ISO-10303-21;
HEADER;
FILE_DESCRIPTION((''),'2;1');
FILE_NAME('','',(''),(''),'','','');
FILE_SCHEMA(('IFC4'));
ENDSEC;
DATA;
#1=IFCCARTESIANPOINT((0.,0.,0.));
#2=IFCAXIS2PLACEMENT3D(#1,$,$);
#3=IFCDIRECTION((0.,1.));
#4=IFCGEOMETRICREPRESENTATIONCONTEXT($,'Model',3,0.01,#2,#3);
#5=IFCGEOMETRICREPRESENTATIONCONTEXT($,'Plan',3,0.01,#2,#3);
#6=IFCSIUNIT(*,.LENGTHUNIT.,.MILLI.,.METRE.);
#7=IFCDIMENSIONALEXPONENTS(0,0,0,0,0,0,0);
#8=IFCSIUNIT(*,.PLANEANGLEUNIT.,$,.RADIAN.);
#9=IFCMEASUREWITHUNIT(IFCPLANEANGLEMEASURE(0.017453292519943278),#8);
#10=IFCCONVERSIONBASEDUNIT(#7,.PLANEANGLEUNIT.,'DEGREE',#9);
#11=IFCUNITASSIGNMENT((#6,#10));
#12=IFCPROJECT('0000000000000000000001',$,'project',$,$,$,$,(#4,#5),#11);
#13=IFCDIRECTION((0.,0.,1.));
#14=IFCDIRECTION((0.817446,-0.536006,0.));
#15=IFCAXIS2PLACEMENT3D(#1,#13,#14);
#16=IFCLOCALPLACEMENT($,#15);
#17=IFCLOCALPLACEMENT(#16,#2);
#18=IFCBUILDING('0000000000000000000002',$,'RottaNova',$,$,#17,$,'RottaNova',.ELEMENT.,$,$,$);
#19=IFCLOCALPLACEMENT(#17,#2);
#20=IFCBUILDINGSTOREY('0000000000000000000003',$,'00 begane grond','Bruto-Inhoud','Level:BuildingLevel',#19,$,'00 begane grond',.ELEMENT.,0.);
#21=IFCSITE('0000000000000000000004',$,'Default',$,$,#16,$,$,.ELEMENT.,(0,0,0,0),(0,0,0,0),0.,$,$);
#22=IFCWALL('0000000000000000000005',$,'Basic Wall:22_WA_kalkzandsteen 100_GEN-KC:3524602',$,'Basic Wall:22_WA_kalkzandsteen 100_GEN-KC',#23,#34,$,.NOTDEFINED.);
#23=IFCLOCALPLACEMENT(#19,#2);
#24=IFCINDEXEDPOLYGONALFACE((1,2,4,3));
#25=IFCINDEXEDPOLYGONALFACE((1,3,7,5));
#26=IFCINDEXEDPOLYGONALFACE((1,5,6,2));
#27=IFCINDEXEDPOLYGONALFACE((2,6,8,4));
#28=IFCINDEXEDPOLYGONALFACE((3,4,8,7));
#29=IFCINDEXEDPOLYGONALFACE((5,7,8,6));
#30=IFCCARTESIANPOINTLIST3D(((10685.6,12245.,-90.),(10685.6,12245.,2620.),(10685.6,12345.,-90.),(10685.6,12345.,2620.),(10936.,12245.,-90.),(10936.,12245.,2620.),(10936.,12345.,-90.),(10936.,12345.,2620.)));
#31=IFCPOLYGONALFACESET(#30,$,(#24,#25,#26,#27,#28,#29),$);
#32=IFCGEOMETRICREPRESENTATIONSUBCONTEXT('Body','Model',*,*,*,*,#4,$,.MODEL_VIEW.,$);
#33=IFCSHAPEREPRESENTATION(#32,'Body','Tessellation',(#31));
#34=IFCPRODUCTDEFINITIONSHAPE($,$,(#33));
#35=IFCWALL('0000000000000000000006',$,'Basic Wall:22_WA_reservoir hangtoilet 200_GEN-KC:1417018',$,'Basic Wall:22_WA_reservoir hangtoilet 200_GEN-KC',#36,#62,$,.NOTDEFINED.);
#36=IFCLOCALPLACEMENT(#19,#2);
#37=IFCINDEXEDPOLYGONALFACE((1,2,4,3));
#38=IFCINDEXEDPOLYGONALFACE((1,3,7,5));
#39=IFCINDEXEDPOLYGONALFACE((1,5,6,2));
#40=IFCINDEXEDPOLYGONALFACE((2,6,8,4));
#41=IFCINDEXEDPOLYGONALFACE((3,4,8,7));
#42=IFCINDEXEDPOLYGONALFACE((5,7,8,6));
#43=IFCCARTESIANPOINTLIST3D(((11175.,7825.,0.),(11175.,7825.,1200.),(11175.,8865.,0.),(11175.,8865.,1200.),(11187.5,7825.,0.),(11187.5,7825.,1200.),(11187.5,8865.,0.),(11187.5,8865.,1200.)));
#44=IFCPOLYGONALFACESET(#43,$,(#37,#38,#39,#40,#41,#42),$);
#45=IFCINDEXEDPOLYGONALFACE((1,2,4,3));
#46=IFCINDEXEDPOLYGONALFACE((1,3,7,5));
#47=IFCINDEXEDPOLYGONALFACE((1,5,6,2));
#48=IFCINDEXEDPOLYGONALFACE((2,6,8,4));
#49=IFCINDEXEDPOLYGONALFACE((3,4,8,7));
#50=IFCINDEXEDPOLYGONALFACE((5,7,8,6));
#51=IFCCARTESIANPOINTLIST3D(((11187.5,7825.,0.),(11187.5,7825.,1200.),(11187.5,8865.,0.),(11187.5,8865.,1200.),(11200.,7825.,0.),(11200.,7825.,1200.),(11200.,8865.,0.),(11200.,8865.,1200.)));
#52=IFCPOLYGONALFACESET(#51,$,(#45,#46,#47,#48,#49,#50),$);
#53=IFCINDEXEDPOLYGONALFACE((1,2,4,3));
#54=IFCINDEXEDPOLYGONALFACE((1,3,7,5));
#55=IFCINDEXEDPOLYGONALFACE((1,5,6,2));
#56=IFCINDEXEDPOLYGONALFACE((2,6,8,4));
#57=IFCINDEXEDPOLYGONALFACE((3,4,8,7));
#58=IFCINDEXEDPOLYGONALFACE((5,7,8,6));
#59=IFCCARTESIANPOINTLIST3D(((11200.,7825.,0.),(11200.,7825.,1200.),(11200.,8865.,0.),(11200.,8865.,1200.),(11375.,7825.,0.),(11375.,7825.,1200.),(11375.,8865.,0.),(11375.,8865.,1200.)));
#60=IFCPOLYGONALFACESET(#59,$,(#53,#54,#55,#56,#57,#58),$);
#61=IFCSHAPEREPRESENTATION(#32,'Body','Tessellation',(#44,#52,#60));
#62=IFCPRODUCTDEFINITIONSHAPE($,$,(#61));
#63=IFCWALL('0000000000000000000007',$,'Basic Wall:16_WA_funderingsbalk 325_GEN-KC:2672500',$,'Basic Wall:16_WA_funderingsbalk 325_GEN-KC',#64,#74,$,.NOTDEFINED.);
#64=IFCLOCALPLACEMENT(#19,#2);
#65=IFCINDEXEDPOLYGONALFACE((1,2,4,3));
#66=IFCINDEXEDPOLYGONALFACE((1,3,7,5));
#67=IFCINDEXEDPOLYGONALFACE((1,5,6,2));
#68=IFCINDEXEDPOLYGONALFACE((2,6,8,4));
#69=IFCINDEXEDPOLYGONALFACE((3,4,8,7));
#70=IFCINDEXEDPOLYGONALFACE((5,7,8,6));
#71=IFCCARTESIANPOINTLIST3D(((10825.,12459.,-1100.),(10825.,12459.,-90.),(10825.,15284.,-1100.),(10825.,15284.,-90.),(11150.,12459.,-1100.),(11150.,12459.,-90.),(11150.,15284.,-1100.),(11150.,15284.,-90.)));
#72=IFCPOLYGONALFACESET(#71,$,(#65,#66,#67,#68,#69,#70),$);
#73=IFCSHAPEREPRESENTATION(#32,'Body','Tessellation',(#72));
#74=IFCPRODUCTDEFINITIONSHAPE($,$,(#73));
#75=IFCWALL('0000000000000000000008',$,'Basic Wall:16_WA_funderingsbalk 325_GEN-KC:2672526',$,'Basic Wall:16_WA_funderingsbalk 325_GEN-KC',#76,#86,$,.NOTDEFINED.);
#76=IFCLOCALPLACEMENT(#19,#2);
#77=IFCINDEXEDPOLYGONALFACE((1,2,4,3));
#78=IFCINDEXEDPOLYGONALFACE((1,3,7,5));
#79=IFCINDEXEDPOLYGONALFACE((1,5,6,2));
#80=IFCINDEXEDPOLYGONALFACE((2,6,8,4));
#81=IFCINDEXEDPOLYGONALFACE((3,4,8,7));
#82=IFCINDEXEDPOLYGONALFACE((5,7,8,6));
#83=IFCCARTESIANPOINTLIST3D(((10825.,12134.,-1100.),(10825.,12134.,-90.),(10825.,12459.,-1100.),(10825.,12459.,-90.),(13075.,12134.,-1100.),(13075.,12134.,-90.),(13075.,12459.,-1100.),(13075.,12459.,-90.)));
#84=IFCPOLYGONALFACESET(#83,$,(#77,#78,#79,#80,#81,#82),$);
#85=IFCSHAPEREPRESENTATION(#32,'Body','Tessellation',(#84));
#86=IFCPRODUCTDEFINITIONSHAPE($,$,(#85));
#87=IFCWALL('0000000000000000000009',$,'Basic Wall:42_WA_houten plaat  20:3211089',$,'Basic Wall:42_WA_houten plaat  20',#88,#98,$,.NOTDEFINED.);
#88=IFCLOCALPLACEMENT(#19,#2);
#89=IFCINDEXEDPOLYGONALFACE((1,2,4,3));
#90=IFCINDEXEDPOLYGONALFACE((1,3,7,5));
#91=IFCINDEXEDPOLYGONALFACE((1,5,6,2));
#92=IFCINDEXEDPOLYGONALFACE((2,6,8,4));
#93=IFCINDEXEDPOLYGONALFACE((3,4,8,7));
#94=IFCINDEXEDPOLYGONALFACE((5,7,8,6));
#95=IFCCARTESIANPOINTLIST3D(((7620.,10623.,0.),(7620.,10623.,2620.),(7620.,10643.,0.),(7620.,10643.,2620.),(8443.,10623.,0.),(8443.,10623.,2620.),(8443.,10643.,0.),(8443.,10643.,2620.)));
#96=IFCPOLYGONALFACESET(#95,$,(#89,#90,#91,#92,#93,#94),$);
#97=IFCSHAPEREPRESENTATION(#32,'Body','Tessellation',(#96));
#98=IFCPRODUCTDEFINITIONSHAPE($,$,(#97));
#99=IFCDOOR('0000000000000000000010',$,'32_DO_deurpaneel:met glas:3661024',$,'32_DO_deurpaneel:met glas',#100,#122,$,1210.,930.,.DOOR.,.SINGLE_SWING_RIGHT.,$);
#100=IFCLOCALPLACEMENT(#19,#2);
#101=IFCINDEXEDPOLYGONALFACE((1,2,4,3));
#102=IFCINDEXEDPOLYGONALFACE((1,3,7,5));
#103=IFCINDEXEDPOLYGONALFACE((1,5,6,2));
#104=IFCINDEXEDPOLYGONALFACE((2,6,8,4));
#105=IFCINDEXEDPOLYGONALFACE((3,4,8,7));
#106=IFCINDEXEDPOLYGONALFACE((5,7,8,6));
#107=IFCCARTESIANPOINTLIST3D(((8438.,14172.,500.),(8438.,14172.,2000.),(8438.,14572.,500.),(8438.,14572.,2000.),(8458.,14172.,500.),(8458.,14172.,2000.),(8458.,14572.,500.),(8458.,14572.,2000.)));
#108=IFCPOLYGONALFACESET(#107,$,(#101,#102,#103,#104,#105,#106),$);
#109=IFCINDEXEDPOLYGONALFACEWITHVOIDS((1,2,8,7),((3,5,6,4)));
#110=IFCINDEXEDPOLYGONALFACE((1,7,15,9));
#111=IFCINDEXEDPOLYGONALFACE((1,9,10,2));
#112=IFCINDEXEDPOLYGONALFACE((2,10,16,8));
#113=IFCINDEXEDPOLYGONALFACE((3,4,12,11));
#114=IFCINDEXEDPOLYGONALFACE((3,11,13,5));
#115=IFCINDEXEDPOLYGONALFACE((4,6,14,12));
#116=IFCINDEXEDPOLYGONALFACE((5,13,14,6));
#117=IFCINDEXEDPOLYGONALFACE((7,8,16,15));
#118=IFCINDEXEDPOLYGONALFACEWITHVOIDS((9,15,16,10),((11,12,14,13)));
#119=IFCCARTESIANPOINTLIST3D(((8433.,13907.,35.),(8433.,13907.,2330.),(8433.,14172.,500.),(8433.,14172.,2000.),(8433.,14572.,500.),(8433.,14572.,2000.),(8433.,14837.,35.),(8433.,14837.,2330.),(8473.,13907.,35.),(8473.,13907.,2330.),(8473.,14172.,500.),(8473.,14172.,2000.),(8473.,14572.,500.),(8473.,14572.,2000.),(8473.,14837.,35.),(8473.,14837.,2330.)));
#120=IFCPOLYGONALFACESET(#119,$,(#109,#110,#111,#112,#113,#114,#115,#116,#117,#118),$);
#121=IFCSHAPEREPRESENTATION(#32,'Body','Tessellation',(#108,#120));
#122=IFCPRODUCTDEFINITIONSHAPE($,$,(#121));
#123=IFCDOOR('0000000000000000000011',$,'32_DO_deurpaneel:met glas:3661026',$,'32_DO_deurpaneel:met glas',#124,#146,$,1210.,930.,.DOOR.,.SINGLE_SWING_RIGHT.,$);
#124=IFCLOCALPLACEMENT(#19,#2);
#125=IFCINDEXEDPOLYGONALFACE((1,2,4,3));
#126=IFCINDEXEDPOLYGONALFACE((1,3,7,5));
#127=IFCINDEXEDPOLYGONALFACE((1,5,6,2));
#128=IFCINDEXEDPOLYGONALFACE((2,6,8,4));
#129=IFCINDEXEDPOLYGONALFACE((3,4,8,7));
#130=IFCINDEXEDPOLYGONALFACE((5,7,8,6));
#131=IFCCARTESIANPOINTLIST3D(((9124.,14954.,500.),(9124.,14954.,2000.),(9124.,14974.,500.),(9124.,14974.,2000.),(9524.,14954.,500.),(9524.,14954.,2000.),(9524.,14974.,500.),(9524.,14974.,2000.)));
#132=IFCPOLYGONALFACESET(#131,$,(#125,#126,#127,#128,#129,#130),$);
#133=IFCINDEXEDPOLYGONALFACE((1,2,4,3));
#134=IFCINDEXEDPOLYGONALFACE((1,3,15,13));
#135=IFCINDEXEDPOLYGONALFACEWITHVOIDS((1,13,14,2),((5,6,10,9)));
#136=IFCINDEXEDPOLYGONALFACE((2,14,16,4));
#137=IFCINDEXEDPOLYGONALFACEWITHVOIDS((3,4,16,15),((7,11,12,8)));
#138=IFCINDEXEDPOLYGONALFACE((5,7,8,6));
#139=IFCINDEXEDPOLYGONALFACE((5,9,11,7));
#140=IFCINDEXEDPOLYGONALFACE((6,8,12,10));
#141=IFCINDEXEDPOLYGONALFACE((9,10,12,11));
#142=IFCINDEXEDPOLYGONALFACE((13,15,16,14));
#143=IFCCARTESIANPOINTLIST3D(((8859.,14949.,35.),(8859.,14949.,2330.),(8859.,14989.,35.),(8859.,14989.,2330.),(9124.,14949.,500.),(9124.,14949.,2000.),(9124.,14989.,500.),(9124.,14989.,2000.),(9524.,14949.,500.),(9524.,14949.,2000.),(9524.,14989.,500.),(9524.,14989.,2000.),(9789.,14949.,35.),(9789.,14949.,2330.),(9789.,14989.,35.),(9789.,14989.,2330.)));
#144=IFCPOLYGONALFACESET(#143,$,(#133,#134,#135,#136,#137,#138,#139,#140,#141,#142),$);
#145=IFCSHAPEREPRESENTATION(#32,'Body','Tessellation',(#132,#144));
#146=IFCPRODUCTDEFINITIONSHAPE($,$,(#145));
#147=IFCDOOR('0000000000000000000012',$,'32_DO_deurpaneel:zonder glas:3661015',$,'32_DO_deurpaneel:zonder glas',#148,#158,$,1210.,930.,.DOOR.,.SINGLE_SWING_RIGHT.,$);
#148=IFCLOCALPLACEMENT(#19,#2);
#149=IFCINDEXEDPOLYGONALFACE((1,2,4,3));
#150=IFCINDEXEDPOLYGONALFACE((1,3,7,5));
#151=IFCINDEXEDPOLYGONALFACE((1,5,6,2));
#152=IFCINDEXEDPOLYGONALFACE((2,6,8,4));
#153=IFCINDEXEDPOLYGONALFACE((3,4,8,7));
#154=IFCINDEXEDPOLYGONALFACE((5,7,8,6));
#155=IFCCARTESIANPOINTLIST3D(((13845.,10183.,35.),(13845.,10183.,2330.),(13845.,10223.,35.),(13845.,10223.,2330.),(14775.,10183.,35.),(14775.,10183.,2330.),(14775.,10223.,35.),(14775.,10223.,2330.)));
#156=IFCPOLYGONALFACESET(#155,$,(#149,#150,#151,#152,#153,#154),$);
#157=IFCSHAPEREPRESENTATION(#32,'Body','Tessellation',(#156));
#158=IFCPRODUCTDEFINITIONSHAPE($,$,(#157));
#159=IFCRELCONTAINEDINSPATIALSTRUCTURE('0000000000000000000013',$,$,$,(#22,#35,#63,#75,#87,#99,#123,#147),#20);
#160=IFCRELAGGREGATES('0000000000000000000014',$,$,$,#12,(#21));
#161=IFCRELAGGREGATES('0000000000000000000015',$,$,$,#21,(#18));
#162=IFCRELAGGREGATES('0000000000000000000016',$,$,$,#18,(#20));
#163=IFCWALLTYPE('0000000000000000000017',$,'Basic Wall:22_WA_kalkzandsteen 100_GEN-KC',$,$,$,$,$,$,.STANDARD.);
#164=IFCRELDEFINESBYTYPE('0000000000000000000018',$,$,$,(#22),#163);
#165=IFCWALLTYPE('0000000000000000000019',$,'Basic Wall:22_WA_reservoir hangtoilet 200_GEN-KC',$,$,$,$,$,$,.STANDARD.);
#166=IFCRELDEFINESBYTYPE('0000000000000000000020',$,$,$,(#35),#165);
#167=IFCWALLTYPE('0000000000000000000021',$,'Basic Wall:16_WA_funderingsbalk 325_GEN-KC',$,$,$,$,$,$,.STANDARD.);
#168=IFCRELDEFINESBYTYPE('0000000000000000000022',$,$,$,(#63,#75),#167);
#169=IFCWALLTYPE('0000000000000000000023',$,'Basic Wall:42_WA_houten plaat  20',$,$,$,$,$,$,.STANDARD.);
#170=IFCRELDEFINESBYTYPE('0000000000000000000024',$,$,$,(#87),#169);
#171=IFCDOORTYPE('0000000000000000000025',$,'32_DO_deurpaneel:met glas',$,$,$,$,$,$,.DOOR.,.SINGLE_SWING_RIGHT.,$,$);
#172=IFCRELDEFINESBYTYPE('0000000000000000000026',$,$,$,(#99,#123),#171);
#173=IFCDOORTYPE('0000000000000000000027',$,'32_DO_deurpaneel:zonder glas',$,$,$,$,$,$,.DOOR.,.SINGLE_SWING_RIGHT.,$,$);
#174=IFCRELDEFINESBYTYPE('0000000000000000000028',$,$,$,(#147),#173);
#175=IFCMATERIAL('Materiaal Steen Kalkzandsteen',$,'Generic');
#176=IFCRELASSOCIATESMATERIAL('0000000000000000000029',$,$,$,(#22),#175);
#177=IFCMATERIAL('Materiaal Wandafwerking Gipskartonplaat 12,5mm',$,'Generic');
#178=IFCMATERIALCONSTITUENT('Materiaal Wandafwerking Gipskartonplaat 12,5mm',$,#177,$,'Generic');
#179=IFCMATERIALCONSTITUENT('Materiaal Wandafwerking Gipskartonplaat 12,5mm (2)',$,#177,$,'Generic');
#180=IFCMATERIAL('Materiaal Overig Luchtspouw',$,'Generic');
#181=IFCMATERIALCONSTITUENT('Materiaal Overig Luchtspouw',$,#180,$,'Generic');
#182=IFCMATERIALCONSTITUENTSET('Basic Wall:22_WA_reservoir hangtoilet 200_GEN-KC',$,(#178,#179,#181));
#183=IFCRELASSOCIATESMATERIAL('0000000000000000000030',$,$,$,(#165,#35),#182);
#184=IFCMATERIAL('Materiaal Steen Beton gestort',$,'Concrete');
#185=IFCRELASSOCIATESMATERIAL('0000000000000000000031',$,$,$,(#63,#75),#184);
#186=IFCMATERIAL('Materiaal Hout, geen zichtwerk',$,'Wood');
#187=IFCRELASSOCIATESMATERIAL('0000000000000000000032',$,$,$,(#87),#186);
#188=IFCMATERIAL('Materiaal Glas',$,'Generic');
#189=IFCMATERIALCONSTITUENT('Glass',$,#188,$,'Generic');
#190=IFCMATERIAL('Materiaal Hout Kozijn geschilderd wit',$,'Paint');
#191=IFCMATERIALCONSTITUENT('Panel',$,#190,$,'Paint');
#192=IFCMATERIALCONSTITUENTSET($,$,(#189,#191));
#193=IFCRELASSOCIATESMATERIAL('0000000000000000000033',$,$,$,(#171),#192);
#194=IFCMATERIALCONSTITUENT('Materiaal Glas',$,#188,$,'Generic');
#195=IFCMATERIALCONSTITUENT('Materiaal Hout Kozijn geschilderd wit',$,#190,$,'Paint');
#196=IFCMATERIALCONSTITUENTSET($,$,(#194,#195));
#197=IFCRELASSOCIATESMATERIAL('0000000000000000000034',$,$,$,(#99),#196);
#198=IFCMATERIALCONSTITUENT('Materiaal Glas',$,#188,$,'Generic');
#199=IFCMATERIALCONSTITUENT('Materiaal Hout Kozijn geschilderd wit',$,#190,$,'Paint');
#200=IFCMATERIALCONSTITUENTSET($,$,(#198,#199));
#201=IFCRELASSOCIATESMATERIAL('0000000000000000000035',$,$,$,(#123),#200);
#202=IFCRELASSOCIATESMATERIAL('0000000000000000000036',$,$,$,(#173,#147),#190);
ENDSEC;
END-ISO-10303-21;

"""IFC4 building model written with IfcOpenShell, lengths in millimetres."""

from ifc_helpers import new_model, entity, si_unit, converted_unit, direction, frame, origin, place, context, subcontext, project, spatial, indexed_curve, outline, extrude, source, transform, mapped, material, constituent, constituent_set, type_object, type_shapes, element, save


model = new_model("IFC4")

# Units and contexts
model_context = context("Model", 3, precision=0.01, world=origin(), true_north=direction((0.0, 1.0)))
plan_context = context("Plan", 3, precision=0.01, world=origin(), true_north=direction((0.0, 1.0)))
body_context = subcontext(model_context, "Body", "Model", "MODEL_VIEW")
ifc_project = project(units=[si_unit("LENGTHUNIT", "METRE", prefix="MILLI"), converted_unit("PLANEANGLEUNIT", "DEGREE", entity("IfcPlaneAngleMeasure", 0.017453292519943278), si_unit("PLANEANGLEUNIT", "RADIAN"), dimensions=[0, 0, 0, 0, 0, 0, 0])], contexts=[model_context, plan_context])

# Site, building, storey
site_placement = place(None, frame((0.0, 0.0, 0.0), z_axis=(0.0, 0.0, 1.0), x_axis=(0.817446, -0.536006, 0.0)))
site = spatial("IfcSite", under=ifc_project, at=site_placement, Name="Default", CompositionType="ELEMENT", RefLatitude=(0, 0, 0, 0), RefLongitude=(0, 0, 0, 0), RefElevation=0.0)
building_placement = place(site_placement, origin())
building = spatial("IfcBuilding", under=site, at=building_placement, Name="RottaNova", LongName="RottaNova", CompositionType="ELEMENT")
storey_placement = place(building_placement, origin())
storey = spatial("IfcBuildingStorey", under=building, at=storey_placement, Name="00 begane grond", Description="Bruto-Inhoud", ObjectType="Level:BuildingLevel", LongName="00 begane grond", CompositionType="ELEMENT", Elevation=0.0)

# Shared definitions
ifc_material_1 = material(Name="Materiaal Steen Kalkzandsteen", Category="Generic")

# Shared definitions
ifc_material_2 = material(Name="Materiaal Wandafwerking Gipskartonplaat 12,5mm", Category="Generic")

# Walls
wall_type_1 = type_object("IfcWallType", Name="Basic Wall:22_WA_kalkzandsteen 100_GEN-KC", PredefinedType="STANDARD")
wall_1_placement = place(storey_placement, frame((10685.6, 12295.0, -90.0)))
element("IfcWall", 1, at=wall_1_placement, inside=storey, type_object=wall_type_1, material=ifc_material_1, Name="Basic Wall:22_WA_kalkzandsteen 100_GEN-KC:3524602", ObjectType="Basic Wall:22_WA_kalkzandsteen 100_GEN-KC", PredefinedType="NOTDEFINED", context=body_context, shape_type="SweptSolid", body=[
    extrude(outline(indexed_curve([(250.4, 50.0), (0.0, 50.0), (0.0, -50.0), (250.4, -50.0), (250.4, 50.0)], self_intersect=False)), origin(), (0.0, 0.0, 1.0), 2710.0),
])
ifc_constituent_1 = constituent(ifc_material_2, Name="Materiaal Wandafwerking Gipskartonplaat 12,5mm", Category="Generic")
ifc_constituent_2 = constituent(ifc_material_2, Name="Materiaal Wandafwerking Gipskartonplaat 12,5mm (2)", Category="Generic")
ifc_material_3 = material(Name="Materiaal Overig Luchtspouw", Category="Generic")
ifc_constituent_3 = constituent(ifc_material_3, Name="Materiaal Overig Luchtspouw", Category="Generic")
ifc_constituent_set_1 = constituent_set(constituents=[ifc_constituent_1, ifc_constituent_2, ifc_constituent_3], Name="Basic Wall:22_WA_reservoir hangtoilet 200_GEN-KC")
wall_type_2 = type_object("IfcWallType", Name="Basic Wall:22_WA_reservoir hangtoilet 200_GEN-KC", PredefinedType="STANDARD", material=ifc_constituent_set_1)
wall_2_placement = place(storey_placement, frame((11275.0, 8865.0, 0.0), z_axis=(0.0, 0.0, 1.0), x_axis=(0.0, -1.0, 0.0)))
element("IfcWall", 2, at=wall_2_placement, inside=storey, type_object=wall_type_2, material=ifc_constituent_set_1, Name="Basic Wall:22_WA_reservoir hangtoilet 200_GEN-KC:1417018", ObjectType="Basic Wall:22_WA_reservoir hangtoilet 200_GEN-KC", PredefinedType="NOTDEFINED", context=body_context, shape_type="SweptSolid", body=[
    extrude(outline(indexed_curve([(-6.2, -520.0), (6.3, -520.0), (6.2, 520.0), (-6.3, 520.0), (-6.2, -520.0)], self_intersect=False)), frame((520.0, -93.7, 0.0), z_axis=(0.0, 0.0, 1.0), x_axis=(0.0, 1.0, 0.0)), (0.0, 0.0, 1.0), 1200.0),
    extrude(outline(indexed_curve([(-520.0, -6.2), (520.0, -6.2), (520.0, 6.2), (-520.0, 6.2), (-520.0, -6.2)], self_intersect=False)), frame((520.0, -81.2, 0.0)), (0.0, 0.0, 1.0), 1200.0),
    extrude(outline(indexed_curve([(-87.5, -520.0), (87.5, -520.0), (87.5, 520.0), (-87.5, 520.0), (-87.5, -520.0)], self_intersect=False)), frame((520.0, 12.5, 0.0), z_axis=(0.0, 0.0, 1.0), x_axis=(0.0, -1.0, 0.0)), (0.0, 0.0, 1.0), 1200.0),
])
ifc_material_4 = material(Name="Materiaal Steen Beton gestort", Category="Concrete")
wall_type_3 = type_object("IfcWallType", Name="Basic Wall:16_WA_funderingsbalk 325_GEN-KC", PredefinedType="STANDARD")
wall_3_placement = place(storey_placement, frame((10987.5, 12459.0, -1100.0), z_axis=(0.0, 0.0, 1.0), x_axis=(0.0, 1.0, 0.0)))
element("IfcWall", 3, at=wall_3_placement, inside=storey, type_object=wall_type_3, material=ifc_material_4, Name="Basic Wall:16_WA_funderingsbalk 325_GEN-KC:2672500", ObjectType="Basic Wall:16_WA_funderingsbalk 325_GEN-KC", PredefinedType="NOTDEFINED", context=body_context, shape_type="SweptSolid", body=[
    extrude(outline(indexed_curve([(2825.0, 162.5), (0.0, 162.5), (0.0, -162.5), (2825.0, -162.5), (2825.0, 162.5)], self_intersect=False)), origin(), (0.0, 0.0, 1.0), 1010.0),
])
wall_4_placement = place(storey_placement, frame((10825.0, 12296.5, -1100.0)))
element("IfcWall", 4, at=wall_4_placement, inside=storey, type_object=wall_type_3, material=ifc_material_4, Name="Basic Wall:16_WA_funderingsbalk 325_GEN-KC:2672526", ObjectType="Basic Wall:16_WA_funderingsbalk 325_GEN-KC", PredefinedType="NOTDEFINED", context=body_context, shape_type="SweptSolid", body=[
    extrude(outline(indexed_curve([(2250.0, 162.5), (0.0, 162.5), (0.0, -162.5), (2250.0, -162.5), (2250.0, 162.5)], self_intersect=False)), origin(), (0.0, 0.0, 1.0), 1010.0),
])
ifc_material_5 = material(Name="Materiaal Hout, geen zichtwerk", Category="Wood")
wall_type_4 = type_object("IfcWallType", Name="Basic Wall:42_WA_houten plaat  20", PredefinedType="STANDARD")
wall_5_placement = place(storey_placement, frame((7620.0, 10633.0, 0.0)))
element("IfcWall", 5, at=wall_5_placement, inside=storey, type_object=wall_type_4, material=ifc_material_5, Name="Basic Wall:42_WA_houten plaat  20:3211089", ObjectType="Basic Wall:42_WA_houten plaat  20", PredefinedType="NOTDEFINED", context=body_context, shape_type="SweptSolid", body=[
    extrude(outline(indexed_curve([(823.0, 10.0), (0.0, 10.0), (0.0, -10.0), (823.0, -10.0), (823.0, 10.0)], self_intersect=False)), origin(), (0.0, 0.0, 1.0), 2620.0),
])

# Doors
ifc_material_6 = material(Name="Materiaal Glas", Category="Generic")
ifc_constituent_4 = constituent(ifc_material_6, Name="Materiaal Glas", Category="Generic")
ifc_material_7 = material(Name="Materiaal Hout Kozijn geschilderd wit", Category="Paint")
ifc_constituent_5 = constituent(ifc_material_7, Name="Materiaal Hout Kozijn geschilderd wit", Category="Paint")
ifc_constituent_set_2 = constituent_set(constituents=[ifc_constituent_4, ifc_constituent_5])
ifc_constituent_6 = constituent(ifc_material_6, Name="Glass", Category="Generic")
ifc_constituent_7 = constituent(ifc_material_7, Name="Panel", Category="Paint")
ifc_constituent_set_3 = constituent_set(constituents=[ifc_constituent_6, ifc_constituent_7])
door_type_1 = type_object("IfcDoorType", Name="32_DO_deurpaneel:met glas", OperationType="SINGLE_SWING_RIGHT", PredefinedType="DOOR", material=ifc_constituent_set_3)
shared_shape_1 = source(origin(), body_context, "Body", "SweptSolid", [
    extrude(outline(indexed_curve([(-200.0, -10.0), (200.0, -10.0), (200.0, 10.0), (-200.0, 10.0), (-200.0, -10.0)], self_intersect=False)), frame((0.0, -25.0, 500.0), z_axis=(0.0, 0.0, 1.0), x_axis=(-1.0, 0.0, 0.0)), (0.0, 0.0, 1.0), 1500.0),
    extrude(outline(indexed_curve([(-465.0, -1147.5), (465.0, -1147.5), (465.0, 1147.5), (-465.0, 1147.5), (-465.0, -1147.5)], self_intersect=False), holes=[indexed_curve([(-200.0, 817.5), (200.0, 817.5), (200.0, -682.5), (-200.0, -682.5), (-200.0, 817.5)], self_intersect=False)]), frame((0.0, -40.0, 1182.5), z_axis=(0.0, 1.0, 0.0), x_axis=(-1.0, 0.0, 0.0)), (0.0, 0.0, 1.0), 40.0),
])
type_shapes(door_type_1, [shared_shape_1])
door_1_placement = place(storey_placement, frame((8473.0, 14372.0, 0.0), z_axis=(0.0, 0.0, 1.0), x_axis=(0.0, -1.0, 0.0)))
element("IfcDoor", 6, at=door_1_placement, inside=storey, type_object=door_type_1, material=ifc_constituent_set_2, Name="32_DO_deurpaneel:met glas:3661024", ObjectType="32_DO_deurpaneel:met glas", OperationType="SINGLE_SWING_RIGHT", OverallHeight=1210.0, OverallWidth=930.0, PredefinedType="DOOR", context=body_context, shape_type="MappedRepresentation", body=[
    mapped(shared_shape_1, transform((0.0, 0.0, 0.0), scale=1.0)),
])
ifc_constituent_8 = constituent(ifc_material_6, Name="Materiaal Glas", Category="Generic")
ifc_constituent_9 = constituent(ifc_material_7, Name="Materiaal Hout Kozijn geschilderd wit", Category="Paint")
ifc_constituent_set_4 = constituent_set(constituents=[ifc_constituent_8, ifc_constituent_9])
door_2_placement = place(storey_placement, frame((9324.0, 14989.0, 0.0)))
element("IfcDoor", 7, at=door_2_placement, inside=storey, type_object=door_type_1, material=ifc_constituent_set_4, Name="32_DO_deurpaneel:met glas:3661026", ObjectType="32_DO_deurpaneel:met glas", OperationType="SINGLE_SWING_RIGHT", OverallHeight=1210.0, OverallWidth=930.0, PredefinedType="DOOR", context=body_context, shape_type="MappedRepresentation", body=[
    mapped(shared_shape_1, transform((0.0, 0.0, 0.0), scale=1.0)),
])
door_type_2 = type_object("IfcDoorType", Name="32_DO_deurpaneel:zonder glas", OperationType="SINGLE_SWING_RIGHT", PredefinedType="DOOR", material=ifc_material_7)
shared_shape_2 = source(origin(), body_context, "Body", "SweptSolid", [
    extrude(outline(indexed_curve([(-1147.5, -20.0), (1147.5, -20.0), (1147.5, 20.0), (-1147.5, 20.0), (-1147.5, -20.0)], self_intersect=False)), frame((-465.0, 20.0, 1182.5), z_axis=(1.0, 0.0, 0.0), x_axis=(0.0, 0.0, 1.0)), (0.0, 0.0, 1.0), 930.0),
])
type_shapes(door_type_2, [shared_shape_2])
door_3_placement = place(storey_placement, frame((14310.0, 10223.0, 0.0), z_axis=(0.0, 0.0, 1.0), x_axis=(-1.0, 0.0, 0.0)))
element("IfcDoor", 8, at=door_3_placement, inside=storey, type_object=door_type_2, material=ifc_material_7, Name="32_DO_deurpaneel:zonder glas:3661015", ObjectType="32_DO_deurpaneel:zonder glas", OperationType="SINGLE_SWING_RIGHT", OverallHeight=1210.0, OverallWidth=930.0, PredefinedType="DOOR", context=body_context, shape_type="MappedRepresentation", body=[
    mapped(shared_shape_2, transform((0.0, 0.0, 0.0), scale=1.0)),
])

save(model, "model.ifc")
